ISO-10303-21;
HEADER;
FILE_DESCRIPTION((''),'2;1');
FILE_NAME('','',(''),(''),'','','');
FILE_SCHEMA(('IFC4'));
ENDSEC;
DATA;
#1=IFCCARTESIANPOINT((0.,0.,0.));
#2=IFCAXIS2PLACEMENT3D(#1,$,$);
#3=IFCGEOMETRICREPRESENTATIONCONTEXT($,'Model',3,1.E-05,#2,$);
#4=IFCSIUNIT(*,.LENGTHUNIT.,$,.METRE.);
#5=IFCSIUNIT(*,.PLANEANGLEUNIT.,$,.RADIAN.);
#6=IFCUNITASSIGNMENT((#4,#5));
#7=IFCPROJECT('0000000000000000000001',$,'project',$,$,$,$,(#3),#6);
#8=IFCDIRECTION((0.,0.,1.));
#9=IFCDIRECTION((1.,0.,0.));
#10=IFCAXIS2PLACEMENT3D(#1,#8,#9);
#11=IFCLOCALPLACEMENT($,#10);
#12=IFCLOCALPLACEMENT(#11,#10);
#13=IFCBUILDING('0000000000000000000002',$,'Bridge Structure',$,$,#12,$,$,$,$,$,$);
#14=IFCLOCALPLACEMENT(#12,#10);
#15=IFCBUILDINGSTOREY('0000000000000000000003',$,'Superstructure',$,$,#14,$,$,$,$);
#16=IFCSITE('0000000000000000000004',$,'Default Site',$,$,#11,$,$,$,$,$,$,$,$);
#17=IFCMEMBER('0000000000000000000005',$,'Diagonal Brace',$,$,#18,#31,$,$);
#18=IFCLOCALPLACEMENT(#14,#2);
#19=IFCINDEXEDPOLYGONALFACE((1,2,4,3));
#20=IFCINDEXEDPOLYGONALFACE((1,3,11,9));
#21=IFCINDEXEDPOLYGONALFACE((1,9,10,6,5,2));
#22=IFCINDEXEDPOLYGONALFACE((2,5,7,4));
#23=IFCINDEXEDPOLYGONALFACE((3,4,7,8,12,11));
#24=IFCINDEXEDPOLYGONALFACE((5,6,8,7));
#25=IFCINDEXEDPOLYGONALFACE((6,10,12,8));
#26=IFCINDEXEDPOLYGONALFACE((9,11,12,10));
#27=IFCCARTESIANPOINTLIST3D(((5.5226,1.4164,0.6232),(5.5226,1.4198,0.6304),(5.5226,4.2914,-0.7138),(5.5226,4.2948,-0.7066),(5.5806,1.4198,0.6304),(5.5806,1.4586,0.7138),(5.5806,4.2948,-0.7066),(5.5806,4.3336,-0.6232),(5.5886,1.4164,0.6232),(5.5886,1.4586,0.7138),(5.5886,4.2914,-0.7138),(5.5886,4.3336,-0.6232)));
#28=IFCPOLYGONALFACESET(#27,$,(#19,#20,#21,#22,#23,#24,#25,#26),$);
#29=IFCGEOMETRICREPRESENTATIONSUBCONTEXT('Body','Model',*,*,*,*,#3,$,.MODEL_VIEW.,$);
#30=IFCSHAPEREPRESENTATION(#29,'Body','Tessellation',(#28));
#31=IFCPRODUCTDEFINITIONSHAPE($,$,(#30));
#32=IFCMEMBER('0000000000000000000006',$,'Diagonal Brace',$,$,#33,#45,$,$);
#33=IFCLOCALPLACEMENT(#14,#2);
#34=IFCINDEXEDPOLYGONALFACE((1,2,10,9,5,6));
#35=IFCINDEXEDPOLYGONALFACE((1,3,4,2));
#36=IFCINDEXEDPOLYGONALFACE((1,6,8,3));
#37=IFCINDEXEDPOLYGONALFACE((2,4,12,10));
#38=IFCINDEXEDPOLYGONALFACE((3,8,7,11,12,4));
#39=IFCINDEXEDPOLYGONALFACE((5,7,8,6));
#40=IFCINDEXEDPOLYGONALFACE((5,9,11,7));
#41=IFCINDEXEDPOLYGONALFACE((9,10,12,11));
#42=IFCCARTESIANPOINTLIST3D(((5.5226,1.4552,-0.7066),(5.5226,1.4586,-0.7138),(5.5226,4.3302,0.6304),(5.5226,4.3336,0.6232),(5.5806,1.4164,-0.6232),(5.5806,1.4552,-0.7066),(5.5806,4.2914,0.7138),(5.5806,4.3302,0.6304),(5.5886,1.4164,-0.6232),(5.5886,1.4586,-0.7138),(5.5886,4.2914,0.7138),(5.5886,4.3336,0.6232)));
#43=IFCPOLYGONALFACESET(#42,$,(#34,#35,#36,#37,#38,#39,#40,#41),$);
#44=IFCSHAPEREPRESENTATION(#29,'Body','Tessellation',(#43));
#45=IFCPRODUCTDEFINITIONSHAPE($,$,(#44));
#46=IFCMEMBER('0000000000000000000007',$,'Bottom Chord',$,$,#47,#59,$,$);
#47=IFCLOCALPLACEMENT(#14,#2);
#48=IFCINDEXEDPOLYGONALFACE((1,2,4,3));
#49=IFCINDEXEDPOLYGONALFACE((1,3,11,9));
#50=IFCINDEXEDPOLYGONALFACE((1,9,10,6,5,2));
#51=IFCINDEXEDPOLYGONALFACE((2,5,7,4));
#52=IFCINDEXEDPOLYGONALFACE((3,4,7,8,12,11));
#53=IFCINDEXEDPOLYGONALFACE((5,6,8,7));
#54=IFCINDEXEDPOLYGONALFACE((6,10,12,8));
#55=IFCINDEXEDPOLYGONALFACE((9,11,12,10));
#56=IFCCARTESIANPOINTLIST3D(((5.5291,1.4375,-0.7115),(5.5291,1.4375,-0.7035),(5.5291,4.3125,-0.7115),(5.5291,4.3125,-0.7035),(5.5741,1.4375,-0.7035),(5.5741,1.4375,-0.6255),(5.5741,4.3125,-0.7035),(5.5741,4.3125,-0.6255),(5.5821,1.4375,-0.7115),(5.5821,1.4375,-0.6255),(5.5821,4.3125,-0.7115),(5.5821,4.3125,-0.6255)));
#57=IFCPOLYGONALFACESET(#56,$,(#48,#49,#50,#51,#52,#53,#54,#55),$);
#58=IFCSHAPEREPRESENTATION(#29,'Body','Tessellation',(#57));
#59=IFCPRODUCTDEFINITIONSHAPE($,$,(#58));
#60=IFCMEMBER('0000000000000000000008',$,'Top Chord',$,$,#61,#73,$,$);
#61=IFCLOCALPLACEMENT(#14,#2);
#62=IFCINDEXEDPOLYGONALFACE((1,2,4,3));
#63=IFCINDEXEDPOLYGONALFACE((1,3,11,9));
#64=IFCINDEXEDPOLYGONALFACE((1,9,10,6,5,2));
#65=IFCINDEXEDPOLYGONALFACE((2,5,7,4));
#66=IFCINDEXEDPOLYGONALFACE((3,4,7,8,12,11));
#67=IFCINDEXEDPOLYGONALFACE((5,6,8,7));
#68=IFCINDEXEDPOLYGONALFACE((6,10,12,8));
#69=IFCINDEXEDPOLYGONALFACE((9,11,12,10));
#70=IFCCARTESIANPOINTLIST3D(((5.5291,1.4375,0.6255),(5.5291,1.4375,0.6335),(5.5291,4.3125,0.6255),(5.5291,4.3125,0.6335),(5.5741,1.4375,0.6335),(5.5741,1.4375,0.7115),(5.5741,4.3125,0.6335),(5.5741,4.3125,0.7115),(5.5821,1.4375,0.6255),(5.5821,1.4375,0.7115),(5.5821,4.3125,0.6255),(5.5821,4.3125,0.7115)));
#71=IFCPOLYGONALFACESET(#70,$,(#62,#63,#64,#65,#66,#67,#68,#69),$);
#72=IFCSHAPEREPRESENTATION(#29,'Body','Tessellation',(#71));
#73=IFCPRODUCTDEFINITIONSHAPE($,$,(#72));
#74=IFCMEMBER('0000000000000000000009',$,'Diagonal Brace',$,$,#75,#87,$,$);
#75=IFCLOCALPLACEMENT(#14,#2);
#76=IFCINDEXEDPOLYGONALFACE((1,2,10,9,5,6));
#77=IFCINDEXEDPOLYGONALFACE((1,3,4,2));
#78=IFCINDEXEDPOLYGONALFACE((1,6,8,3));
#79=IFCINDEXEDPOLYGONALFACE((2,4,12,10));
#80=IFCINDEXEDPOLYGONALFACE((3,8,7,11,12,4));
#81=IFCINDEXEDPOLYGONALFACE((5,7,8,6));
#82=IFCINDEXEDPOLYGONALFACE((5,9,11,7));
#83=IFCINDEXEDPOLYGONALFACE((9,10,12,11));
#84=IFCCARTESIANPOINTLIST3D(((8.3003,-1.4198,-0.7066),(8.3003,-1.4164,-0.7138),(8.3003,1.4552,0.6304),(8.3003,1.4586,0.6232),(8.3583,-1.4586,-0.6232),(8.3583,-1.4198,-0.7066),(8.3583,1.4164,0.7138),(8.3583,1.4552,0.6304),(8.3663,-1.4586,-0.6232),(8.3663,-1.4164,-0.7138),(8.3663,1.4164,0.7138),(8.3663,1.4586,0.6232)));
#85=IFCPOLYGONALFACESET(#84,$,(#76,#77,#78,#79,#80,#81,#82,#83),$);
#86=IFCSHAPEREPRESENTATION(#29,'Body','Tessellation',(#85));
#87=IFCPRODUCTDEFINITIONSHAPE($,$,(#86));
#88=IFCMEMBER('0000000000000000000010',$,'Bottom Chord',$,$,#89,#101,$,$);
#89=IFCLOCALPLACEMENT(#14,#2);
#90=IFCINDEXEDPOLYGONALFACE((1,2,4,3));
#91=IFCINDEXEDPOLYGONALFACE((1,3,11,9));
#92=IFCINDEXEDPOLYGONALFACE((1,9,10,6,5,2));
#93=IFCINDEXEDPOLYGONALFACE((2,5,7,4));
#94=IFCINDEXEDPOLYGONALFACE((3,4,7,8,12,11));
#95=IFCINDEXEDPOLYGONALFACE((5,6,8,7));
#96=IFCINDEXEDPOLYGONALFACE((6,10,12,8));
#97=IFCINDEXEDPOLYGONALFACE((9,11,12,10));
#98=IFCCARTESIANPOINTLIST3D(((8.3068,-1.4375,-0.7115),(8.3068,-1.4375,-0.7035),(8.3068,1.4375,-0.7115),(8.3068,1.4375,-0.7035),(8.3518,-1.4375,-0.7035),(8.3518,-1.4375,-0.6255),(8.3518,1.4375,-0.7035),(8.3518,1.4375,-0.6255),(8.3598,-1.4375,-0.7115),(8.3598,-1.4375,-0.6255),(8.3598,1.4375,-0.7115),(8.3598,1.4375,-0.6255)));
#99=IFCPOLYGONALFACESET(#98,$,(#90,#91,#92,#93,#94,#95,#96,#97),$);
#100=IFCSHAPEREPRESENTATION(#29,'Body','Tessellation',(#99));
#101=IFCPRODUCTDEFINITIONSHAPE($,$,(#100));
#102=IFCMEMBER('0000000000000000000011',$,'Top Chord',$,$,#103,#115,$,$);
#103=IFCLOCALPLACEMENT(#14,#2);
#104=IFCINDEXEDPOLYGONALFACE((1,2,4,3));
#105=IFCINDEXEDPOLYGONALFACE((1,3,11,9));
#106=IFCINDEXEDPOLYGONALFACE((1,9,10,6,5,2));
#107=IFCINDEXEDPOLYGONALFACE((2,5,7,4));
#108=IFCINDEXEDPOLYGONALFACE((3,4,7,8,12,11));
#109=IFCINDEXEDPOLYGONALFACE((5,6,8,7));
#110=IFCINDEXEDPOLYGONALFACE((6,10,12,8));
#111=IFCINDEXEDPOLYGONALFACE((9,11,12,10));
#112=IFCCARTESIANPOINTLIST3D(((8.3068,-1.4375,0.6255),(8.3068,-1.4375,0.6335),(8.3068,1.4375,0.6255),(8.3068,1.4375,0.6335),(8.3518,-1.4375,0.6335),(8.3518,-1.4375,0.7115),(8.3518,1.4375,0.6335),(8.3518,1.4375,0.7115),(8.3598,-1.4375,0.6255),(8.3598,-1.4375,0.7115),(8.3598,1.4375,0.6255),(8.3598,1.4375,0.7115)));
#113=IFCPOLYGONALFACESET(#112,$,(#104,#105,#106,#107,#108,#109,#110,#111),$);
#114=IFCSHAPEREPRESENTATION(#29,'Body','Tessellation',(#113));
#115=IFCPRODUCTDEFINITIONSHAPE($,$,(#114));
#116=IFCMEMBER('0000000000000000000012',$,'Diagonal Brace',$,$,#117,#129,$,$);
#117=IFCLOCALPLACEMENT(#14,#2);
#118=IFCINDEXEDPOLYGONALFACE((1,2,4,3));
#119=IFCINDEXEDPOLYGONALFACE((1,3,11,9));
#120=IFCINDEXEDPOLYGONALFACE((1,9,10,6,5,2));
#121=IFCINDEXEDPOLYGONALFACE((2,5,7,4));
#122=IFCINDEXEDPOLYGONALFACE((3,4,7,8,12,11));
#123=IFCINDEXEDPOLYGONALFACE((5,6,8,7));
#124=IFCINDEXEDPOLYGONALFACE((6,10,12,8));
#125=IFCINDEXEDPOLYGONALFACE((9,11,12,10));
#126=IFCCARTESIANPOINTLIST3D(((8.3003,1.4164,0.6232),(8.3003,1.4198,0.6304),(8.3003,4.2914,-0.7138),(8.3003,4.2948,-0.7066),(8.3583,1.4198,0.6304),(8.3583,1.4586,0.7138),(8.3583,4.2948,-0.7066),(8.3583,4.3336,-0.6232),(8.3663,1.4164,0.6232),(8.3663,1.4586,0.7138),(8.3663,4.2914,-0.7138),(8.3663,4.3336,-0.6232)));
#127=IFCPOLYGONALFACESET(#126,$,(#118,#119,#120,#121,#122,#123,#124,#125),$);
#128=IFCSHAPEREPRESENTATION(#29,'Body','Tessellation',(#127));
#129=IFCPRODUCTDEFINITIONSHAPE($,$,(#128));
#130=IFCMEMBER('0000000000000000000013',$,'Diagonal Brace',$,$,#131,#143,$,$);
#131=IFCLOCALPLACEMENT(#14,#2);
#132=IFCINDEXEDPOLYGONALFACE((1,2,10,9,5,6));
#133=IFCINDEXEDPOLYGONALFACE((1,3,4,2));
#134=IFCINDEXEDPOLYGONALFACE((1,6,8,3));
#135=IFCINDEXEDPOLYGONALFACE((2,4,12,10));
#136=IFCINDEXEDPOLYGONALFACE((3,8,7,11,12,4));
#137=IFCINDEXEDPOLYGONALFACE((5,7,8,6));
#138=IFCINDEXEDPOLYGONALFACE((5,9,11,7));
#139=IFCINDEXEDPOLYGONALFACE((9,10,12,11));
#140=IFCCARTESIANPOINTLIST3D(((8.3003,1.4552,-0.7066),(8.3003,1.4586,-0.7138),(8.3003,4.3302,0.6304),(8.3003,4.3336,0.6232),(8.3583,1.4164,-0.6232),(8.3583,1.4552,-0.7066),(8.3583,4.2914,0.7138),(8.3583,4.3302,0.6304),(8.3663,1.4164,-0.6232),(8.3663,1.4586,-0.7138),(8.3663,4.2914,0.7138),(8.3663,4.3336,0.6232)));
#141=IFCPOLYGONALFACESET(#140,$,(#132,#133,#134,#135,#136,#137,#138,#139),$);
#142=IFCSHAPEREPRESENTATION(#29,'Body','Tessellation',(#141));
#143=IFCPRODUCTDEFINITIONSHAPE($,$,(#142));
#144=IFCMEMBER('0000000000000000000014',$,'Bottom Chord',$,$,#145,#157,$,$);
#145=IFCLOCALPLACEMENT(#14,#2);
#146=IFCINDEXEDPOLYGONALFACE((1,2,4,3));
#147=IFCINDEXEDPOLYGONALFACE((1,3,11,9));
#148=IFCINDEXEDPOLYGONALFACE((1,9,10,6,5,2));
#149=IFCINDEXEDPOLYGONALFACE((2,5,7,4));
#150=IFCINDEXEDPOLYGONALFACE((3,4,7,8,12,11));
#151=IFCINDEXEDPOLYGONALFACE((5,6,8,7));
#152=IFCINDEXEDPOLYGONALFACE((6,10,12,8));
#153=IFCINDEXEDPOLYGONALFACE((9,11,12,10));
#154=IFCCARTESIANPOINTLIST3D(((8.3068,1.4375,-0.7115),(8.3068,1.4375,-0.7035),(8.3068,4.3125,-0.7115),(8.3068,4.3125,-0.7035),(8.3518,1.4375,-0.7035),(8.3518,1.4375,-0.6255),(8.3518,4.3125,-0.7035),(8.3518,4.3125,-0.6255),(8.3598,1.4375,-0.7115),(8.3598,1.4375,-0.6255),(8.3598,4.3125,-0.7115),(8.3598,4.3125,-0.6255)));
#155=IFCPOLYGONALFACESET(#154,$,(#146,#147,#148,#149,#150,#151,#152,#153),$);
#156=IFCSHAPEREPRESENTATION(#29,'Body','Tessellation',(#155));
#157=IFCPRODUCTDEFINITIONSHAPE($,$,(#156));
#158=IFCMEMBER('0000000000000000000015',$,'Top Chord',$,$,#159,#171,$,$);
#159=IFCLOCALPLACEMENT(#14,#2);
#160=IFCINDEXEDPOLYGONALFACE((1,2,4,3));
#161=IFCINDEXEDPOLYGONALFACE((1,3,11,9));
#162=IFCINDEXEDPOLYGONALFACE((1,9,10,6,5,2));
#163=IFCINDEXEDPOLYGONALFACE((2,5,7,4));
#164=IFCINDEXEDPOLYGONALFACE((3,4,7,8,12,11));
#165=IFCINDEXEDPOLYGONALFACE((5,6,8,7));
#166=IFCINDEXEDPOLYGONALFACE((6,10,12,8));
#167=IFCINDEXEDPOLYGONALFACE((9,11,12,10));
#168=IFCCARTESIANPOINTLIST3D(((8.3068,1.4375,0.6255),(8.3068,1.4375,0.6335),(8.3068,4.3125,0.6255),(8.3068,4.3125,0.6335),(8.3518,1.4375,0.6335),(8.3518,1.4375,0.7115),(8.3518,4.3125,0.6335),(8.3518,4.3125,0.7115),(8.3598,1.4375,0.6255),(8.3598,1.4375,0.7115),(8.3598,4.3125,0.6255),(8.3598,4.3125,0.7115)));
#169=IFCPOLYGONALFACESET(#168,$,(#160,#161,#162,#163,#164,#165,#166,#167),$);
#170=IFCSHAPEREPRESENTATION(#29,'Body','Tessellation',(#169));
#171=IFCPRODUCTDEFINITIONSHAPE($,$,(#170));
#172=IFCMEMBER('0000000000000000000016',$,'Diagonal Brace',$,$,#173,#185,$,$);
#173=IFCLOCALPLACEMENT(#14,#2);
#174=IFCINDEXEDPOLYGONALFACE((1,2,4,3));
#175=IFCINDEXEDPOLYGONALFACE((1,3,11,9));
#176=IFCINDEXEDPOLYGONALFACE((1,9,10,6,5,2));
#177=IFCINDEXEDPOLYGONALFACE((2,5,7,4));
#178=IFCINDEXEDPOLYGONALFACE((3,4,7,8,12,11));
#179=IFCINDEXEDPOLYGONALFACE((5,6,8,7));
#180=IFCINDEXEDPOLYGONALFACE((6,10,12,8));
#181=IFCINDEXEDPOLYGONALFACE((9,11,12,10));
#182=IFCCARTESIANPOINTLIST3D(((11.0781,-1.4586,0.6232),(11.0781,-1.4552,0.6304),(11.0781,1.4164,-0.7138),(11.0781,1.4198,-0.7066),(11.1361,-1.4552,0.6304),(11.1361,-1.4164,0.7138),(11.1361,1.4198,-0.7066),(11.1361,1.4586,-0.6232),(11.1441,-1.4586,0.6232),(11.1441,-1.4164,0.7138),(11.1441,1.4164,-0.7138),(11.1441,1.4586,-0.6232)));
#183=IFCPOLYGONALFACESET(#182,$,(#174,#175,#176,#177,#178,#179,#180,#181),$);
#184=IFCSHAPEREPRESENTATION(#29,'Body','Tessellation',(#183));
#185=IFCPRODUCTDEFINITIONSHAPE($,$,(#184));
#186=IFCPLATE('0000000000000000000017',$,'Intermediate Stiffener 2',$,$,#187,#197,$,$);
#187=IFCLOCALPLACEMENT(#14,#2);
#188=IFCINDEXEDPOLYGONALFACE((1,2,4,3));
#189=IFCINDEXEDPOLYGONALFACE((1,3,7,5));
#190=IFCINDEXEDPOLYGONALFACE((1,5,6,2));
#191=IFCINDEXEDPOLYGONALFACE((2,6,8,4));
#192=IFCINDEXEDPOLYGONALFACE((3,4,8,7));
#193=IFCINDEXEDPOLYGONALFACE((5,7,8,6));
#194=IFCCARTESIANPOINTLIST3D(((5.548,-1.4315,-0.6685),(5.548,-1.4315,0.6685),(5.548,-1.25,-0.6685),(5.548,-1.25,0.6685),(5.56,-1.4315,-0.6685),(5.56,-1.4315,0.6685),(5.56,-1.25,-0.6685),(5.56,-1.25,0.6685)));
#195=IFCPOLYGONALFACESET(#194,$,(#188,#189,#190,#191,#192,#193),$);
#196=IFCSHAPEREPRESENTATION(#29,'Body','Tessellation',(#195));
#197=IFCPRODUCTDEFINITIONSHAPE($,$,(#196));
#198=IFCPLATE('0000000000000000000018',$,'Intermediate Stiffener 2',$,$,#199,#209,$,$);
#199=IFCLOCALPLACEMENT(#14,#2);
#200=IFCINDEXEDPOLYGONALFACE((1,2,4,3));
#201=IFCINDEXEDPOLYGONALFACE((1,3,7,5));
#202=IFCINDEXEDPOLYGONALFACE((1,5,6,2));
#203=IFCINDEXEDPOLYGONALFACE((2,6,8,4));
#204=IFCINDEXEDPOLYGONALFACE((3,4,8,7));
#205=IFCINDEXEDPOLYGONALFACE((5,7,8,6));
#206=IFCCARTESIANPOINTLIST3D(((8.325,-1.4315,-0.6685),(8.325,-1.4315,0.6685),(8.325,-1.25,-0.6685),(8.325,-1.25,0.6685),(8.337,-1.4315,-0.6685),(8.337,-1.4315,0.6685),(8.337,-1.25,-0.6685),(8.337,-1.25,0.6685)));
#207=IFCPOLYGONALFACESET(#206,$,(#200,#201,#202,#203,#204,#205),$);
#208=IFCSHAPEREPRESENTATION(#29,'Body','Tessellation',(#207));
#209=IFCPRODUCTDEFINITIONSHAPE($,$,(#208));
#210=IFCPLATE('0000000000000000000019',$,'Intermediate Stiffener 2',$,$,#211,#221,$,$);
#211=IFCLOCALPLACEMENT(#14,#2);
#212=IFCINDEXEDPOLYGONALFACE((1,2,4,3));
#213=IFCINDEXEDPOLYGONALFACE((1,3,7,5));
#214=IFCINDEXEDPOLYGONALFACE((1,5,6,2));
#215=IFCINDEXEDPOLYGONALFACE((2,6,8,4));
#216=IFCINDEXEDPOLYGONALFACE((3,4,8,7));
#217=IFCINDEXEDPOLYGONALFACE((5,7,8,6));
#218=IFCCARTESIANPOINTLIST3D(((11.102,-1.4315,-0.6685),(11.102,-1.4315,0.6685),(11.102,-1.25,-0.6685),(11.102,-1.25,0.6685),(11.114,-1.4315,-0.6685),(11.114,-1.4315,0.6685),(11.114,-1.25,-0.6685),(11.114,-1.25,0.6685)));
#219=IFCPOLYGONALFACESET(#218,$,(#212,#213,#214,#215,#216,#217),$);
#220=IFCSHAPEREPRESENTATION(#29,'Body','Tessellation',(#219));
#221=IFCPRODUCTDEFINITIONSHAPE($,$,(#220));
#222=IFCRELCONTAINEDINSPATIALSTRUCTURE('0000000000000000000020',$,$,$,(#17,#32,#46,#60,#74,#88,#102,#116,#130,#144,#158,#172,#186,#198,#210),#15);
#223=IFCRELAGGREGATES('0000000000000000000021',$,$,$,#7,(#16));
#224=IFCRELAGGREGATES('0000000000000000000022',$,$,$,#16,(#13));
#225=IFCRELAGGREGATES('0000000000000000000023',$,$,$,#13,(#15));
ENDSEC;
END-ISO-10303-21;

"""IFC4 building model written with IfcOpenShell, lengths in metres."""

from ifc_helpers import new_model, si_unit, frame, origin, origin_with_axes, origin_2d_with_axis, place, context, subcontext, project, spatial, rectangle, l_section, extrude, element, save


model = new_model("IFC4")

# Units and contexts
model_context = context("Model", 3, precision=1e-05, world=origin())
body_context = subcontext(model_context, "Body", "Model", "MODEL_VIEW")
ifc_project = project(units=[si_unit("LENGTHUNIT", "METRE"), si_unit("PLANEANGLEUNIT", "RADIAN")], contexts=[model_context])

# Site, building, storey
site_placement = place(None, origin_with_axes())
site = spatial("IfcSite", under=ifc_project, at=site_placement, Name="Default Site")
building_placement = place(site_placement, origin_with_axes())
building = spatial("IfcBuilding", under=site, at=building_placement, Name="Bridge Structure")
storey_placement = place(building_placement, origin_with_axes())
storey = spatial("IfcBuildingStorey", under=building, at=storey_placement, Name="Superstructure")

# Members
for number, where, z_axis, x_axis, name in (
    (1, (5.5556, 1.4375, 0.6685), (0.0, 0.906746, -0.421676), (-1.0, 0.0, 0.0), "Diagonal Brace"),
    (2, (5.5556, 1.4375, -0.6685), (0.0, 0.906746, 0.421676), (-1.0, 0.0, 0.0), "Diagonal Brace"),
):
    element("IfcMember", number, at=place(storey_placement, frame(where, z_axis=z_axis, x_axis=x_axis)), inside=storey, Name=name, context=body_context, shape_type="SweptSolid", body=[
        extrude(l_section(Depth=0.1, Width=0.066, Thickness=0.008, at=origin_2d_with_axis()), origin_with_axes(), (0.0, 0.0, 1.0), 3.1707),
    ])
for number, where, z_axis, x_axis, name in (
    (3, (5.5556, 1.4375, -0.6685), (0.0, 1.0, 0.0), (-1.0, 0.0, 0.0), "Bottom Chord"),
    (4, (5.5556, 1.4375, 0.6685), (0.0, 1.0, 0.0), (-1.0, 0.0, 0.0), "Top Chord"),
):
    element("IfcMember", number, at=place(storey_placement, frame(where, z_axis=z_axis, x_axis=x_axis)), inside=storey, Name=name, context=body_context, shape_type="SweptSolid", body=[
        extrude(l_section(Depth=0.086, Width=0.053, Thickness=0.008, at=origin_2d_with_axis()), origin_with_axes(), (0.0, 0.0, 1.0), 2.875),
    ])
member_1_placement = place(storey_placement, frame((8.3333, -1.4375, -0.6685), z_axis=(0.0, 0.906746, 0.421676), x_axis=(-1.0, 0.0, 0.0)))
element("IfcMember", 5, at=member_1_placement, inside=storey, Name="Diagonal Brace", context=body_context, shape_type="SweptSolid", body=[
    extrude(l_section(Depth=0.1, Width=0.066, Thickness=0.008, at=origin_2d_with_axis()), origin_with_axes(), (0.0, 0.0, 1.0), 3.1707),
])
for number, where, z_axis, x_axis, name in (
    (6, (8.3333, -1.4375, -0.6685), (0.0, 1.0, 0.0), (-1.0, 0.0, 0.0), "Bottom Chord"),
    (7, (8.3333, -1.4375, 0.6685), (0.0, 1.0, 0.0), (-1.0, 0.0, 0.0), "Top Chord"),
):
    element("IfcMember", number, at=place(storey_placement, frame(where, z_axis=z_axis, x_axis=x_axis)), inside=storey, Name=name, context=body_context, shape_type="SweptSolid", body=[
        extrude(l_section(Depth=0.086, Width=0.053, Thickness=0.008, at=origin_2d_with_axis()), origin_with_axes(), (0.0, 0.0, 1.0), 2.875),
    ])
for number, where, z_axis, x_axis, name in (
    (8, (8.3333, 1.4375, 0.6685), (0.0, 0.906746, -0.421676), (-1.0, 0.0, 0.0), "Diagonal Brace"),
    (9, (8.3333, 1.4375, -0.6685), (0.0, 0.906746, 0.421676), (-1.0, 0.0, 0.0), "Diagonal Brace"),
):
    element("IfcMember", number, at=place(storey_placement, frame(where, z_axis=z_axis, x_axis=x_axis)), inside=storey, Name=name, context=body_context, shape_type="SweptSolid", body=[
        extrude(l_section(Depth=0.1, Width=0.066, Thickness=0.008, at=origin_2d_with_axis()), origin_with_axes(), (0.0, 0.0, 1.0), 3.1707),
    ])
for number, where, z_axis, x_axis, name in (
    (10, (8.3333, 1.4375, -0.6685), (0.0, 1.0, 0.0), (-1.0, 0.0, 0.0), "Bottom Chord"),
    (11, (8.3333, 1.4375, 0.6685), (0.0, 1.0, 0.0), (-1.0, 0.0, 0.0), "Top Chord"),
):
    element("IfcMember", number, at=place(storey_placement, frame(where, z_axis=z_axis, x_axis=x_axis)), inside=storey, Name=name, context=body_context, shape_type="SweptSolid", body=[
        extrude(l_section(Depth=0.086, Width=0.053, Thickness=0.008, at=origin_2d_with_axis()), origin_with_axes(), (0.0, 0.0, 1.0), 2.875),
    ])
member_2_placement = place(storey_placement, frame((11.1111, -1.4375, 0.6685), z_axis=(0.0, 0.906746, -0.421676), x_axis=(-1.0, 0.0, 0.0)))
element("IfcMember", 12, at=member_2_placement, inside=storey, Name="Diagonal Brace", context=body_context, shape_type="SweptSolid", body=[
    extrude(l_section(Depth=0.1, Width=0.066, Thickness=0.008, at=origin_2d_with_axis()), origin_with_axes(), (0.0, 0.0, 1.0), 3.1707),
])

# Plates
for number, where, z_axis, x_axis, name in (
    (13, (5.554, -1.3408, -0.6685), (0.0, 0.0, 1.0), (1.0, 0.0, 0.0), "Intermediate Stiffener 2"),
    (14, (8.331, -1.3408, -0.6685), (0.0, 0.0, 1.0), (1.0, 0.0, 0.0), "Intermediate Stiffener 2"),
    (15, (11.108, -1.3408, -0.6685), (0.0, 0.0, 1.0), (1.0, 0.0, 0.0), "Intermediate Stiffener 2"),
):
    element("IfcPlate", number, at=place(storey_placement, frame(where, z_axis=z_axis, x_axis=x_axis)), inside=storey, Name=name, context=body_context, shape_type="SweptSolid", body=[
        extrude(rectangle(XDim=0.012, YDim=0.1815, at=origin_2d_with_axis()), origin_with_axes(), (0.0, 0.0, 1.0), 1.337),
    ])

save(model, "model.ifc")
